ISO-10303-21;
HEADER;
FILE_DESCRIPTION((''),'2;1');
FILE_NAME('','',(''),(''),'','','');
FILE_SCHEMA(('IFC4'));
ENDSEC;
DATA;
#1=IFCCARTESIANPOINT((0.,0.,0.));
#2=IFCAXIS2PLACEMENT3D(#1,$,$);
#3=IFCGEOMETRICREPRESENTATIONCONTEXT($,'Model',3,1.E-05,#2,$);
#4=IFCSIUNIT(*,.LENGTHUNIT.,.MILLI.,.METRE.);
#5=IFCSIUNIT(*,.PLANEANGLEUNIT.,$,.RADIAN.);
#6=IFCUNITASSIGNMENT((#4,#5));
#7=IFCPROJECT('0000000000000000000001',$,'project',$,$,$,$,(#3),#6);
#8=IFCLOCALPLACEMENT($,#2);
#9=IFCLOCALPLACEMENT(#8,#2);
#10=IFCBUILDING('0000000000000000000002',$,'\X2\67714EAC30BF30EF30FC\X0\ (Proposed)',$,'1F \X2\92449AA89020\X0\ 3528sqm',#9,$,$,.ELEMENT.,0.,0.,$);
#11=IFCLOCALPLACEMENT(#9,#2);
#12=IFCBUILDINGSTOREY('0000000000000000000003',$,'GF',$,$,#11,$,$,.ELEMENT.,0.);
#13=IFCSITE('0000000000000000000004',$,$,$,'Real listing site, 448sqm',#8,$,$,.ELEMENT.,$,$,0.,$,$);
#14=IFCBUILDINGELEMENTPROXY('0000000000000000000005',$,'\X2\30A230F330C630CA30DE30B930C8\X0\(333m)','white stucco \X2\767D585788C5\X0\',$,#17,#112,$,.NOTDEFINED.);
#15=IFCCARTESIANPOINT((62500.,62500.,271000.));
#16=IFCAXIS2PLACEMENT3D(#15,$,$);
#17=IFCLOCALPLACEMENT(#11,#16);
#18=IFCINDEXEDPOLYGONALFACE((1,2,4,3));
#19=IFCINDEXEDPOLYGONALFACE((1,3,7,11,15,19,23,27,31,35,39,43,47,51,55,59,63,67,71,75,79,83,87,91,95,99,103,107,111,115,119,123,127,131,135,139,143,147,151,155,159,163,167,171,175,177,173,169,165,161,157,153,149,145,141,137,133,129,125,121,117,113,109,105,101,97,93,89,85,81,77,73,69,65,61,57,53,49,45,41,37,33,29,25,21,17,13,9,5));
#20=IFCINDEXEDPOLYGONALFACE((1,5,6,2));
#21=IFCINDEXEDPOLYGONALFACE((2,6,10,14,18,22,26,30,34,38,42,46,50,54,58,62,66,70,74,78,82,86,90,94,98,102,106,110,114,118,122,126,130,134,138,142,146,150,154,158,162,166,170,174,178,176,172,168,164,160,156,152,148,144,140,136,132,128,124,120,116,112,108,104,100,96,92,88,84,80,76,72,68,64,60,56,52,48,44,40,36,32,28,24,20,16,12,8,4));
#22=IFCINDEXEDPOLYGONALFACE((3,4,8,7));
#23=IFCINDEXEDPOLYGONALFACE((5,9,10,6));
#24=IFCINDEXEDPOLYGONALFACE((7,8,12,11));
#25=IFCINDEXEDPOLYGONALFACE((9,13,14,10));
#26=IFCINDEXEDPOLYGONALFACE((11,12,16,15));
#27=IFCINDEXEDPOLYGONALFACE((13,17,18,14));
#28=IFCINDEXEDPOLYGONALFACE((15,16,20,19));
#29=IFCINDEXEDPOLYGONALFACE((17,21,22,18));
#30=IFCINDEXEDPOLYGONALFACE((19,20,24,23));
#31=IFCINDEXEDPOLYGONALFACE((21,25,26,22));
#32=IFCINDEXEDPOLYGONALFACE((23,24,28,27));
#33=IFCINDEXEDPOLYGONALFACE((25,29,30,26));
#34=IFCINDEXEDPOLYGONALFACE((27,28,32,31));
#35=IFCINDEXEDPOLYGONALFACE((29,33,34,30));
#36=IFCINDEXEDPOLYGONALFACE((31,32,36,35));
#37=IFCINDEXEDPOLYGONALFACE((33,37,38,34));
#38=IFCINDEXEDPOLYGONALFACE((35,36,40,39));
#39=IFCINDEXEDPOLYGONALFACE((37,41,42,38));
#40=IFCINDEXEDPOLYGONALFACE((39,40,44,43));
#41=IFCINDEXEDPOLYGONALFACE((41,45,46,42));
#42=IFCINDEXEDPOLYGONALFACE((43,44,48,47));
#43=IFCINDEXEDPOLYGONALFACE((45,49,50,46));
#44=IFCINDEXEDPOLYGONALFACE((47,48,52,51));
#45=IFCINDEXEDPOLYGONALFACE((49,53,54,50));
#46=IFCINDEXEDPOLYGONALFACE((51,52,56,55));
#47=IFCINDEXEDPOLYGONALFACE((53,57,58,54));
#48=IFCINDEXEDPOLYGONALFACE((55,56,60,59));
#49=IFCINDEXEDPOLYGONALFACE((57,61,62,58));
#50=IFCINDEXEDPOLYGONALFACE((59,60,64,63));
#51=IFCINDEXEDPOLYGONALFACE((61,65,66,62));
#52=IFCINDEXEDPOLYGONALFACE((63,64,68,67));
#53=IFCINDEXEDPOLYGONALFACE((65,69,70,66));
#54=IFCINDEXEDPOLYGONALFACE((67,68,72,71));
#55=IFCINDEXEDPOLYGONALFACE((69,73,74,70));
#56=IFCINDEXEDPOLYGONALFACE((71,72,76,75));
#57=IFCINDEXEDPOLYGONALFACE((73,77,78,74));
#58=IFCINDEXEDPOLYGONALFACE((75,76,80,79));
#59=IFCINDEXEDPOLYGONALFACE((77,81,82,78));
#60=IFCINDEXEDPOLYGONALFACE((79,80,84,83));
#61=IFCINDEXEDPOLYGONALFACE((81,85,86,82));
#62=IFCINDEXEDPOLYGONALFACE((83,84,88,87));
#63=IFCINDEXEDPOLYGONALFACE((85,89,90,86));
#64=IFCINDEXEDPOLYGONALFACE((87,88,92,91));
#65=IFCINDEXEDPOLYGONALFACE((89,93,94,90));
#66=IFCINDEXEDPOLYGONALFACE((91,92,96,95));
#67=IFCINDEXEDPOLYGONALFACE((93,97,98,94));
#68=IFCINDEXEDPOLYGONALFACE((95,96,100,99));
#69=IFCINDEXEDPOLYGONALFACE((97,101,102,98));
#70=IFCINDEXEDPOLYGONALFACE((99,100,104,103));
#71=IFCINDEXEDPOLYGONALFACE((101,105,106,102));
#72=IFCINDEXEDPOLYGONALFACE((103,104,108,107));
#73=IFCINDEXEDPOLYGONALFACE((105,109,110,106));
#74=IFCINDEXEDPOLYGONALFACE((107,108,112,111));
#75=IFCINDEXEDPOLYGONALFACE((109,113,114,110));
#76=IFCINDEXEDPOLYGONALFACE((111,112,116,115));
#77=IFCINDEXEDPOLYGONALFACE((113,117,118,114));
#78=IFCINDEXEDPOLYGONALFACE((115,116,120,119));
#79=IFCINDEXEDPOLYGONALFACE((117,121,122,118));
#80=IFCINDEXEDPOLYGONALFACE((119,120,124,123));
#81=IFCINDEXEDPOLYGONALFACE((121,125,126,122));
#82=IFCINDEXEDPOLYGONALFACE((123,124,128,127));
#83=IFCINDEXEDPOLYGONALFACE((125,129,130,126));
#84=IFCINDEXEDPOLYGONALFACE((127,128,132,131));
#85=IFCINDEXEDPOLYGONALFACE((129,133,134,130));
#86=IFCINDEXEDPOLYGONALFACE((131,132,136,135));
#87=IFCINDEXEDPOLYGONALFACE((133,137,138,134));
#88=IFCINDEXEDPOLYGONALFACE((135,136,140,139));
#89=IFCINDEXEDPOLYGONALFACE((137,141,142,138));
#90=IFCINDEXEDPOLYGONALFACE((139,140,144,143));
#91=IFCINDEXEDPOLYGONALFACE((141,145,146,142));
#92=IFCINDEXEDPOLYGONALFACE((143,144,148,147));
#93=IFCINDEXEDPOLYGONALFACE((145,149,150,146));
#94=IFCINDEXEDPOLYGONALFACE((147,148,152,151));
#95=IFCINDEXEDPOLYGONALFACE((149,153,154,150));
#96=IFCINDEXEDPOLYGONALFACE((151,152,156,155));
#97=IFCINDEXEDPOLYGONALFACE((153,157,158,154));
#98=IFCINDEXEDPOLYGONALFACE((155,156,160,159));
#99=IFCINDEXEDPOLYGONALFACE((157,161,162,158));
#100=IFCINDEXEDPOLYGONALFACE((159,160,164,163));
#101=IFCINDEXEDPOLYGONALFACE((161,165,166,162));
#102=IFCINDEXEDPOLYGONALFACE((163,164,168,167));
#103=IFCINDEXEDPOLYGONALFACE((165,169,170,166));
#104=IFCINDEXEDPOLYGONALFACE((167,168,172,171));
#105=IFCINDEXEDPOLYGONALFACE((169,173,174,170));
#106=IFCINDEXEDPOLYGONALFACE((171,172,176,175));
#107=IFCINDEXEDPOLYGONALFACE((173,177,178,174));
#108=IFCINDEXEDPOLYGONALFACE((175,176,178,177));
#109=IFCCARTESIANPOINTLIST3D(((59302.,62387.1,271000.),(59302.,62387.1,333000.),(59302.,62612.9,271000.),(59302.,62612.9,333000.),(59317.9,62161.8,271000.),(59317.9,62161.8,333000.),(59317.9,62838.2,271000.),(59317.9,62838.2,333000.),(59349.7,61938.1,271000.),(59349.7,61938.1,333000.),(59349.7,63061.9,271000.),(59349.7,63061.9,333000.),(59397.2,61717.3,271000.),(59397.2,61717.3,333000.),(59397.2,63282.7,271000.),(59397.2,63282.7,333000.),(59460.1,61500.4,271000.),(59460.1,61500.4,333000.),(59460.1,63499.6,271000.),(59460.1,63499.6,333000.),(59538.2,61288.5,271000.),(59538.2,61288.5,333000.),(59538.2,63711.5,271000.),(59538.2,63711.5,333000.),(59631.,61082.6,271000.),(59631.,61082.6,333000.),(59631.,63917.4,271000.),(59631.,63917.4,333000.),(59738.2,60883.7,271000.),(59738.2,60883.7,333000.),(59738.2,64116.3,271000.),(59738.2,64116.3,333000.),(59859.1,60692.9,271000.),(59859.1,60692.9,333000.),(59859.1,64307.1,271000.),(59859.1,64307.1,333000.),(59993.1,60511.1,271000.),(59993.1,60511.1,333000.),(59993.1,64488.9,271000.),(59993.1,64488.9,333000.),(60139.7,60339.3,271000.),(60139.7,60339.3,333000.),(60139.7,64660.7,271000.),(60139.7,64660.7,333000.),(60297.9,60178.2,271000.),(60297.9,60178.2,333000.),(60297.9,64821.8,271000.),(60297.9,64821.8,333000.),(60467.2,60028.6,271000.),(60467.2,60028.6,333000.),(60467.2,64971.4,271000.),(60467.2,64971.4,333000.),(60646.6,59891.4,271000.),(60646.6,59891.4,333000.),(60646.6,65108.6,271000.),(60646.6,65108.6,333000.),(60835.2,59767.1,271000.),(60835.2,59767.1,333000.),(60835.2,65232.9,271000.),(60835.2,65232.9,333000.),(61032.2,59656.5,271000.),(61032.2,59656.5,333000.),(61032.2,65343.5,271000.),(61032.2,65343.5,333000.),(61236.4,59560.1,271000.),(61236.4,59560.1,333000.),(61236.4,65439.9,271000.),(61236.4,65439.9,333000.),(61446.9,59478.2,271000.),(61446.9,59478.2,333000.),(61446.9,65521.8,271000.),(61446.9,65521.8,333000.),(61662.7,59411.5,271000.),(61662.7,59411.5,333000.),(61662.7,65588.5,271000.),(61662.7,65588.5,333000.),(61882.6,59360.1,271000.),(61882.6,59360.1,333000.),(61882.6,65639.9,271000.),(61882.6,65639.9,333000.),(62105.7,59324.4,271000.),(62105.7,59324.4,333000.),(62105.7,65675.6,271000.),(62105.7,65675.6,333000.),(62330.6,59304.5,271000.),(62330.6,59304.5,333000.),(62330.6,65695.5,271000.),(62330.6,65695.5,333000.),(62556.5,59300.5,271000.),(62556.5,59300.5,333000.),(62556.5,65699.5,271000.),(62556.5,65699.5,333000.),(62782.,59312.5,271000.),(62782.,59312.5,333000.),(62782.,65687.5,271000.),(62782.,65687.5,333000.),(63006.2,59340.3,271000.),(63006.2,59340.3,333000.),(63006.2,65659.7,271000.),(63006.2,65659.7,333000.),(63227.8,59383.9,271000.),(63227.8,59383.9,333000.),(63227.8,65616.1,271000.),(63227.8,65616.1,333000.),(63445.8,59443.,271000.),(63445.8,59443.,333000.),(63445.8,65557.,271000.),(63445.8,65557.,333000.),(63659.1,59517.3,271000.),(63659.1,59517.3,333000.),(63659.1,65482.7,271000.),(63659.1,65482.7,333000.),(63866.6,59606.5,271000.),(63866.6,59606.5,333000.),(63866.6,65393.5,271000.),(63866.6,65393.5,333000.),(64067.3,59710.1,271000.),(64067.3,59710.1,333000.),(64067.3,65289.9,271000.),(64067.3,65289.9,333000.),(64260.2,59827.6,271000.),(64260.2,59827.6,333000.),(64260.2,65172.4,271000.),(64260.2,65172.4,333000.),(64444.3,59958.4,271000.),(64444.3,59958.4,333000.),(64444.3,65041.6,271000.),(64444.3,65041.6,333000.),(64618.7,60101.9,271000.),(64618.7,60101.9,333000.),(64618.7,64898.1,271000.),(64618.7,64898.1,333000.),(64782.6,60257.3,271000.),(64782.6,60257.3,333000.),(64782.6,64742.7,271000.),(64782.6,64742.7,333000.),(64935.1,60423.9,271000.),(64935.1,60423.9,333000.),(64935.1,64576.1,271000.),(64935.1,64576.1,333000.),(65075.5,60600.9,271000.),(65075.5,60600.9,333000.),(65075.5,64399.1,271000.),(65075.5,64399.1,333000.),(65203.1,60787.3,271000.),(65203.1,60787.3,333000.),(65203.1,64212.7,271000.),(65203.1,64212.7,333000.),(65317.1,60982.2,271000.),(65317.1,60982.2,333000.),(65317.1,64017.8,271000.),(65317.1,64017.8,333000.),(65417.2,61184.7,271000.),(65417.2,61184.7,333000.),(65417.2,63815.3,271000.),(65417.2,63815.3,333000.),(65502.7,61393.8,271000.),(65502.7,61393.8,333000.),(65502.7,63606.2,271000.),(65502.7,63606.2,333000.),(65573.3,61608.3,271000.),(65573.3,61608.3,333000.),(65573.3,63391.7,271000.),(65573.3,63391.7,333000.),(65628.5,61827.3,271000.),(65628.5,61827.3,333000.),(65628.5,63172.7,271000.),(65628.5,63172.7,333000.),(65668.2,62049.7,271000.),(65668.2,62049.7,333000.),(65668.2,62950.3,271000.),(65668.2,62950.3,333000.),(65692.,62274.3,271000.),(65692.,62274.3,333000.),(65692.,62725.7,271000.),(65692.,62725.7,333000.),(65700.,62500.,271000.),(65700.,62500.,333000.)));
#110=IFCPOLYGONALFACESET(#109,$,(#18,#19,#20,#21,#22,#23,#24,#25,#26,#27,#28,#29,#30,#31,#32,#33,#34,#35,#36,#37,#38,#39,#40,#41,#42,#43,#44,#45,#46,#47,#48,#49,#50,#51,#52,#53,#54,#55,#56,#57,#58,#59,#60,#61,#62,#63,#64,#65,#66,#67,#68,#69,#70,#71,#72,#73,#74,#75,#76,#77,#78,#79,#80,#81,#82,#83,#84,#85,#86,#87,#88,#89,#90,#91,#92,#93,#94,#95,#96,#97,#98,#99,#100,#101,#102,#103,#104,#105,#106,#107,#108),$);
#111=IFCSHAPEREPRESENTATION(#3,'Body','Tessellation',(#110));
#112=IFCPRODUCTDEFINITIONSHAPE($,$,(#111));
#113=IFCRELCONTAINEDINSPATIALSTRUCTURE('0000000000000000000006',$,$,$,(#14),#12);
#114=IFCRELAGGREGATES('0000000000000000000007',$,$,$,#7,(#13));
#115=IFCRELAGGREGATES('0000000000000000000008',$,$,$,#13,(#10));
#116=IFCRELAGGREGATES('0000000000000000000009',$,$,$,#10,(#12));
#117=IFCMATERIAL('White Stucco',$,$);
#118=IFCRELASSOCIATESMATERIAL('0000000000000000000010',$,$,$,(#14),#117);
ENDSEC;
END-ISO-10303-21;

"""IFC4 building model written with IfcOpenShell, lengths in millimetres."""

from ifc_helpers import new_model, si_unit, frame, origin, origin_2d, place, context, project, spatial, circle, extrude, material, element, save


model = new_model("IFC4")

# Units and contexts
model_context = context("Model", 3, precision=1e-05, world=origin())
ifc_project = project(units=[si_unit("LENGTHUNIT", "METRE", prefix="MILLI"), si_unit("PLANEANGLEUNIT", "RADIAN")], contexts=[model_context])

# Site, building, storey
site_placement = place(None, origin())
site = spatial("IfcSite", under=ifc_project, at=site_placement, ObjectType="Real listing site, 448sqm", CompositionType="ELEMENT", RefElevation=0.0)
building_placement = place(site_placement, origin())
building = spatial("IfcBuilding", under=site, at=building_placement, Name="東京タワー (Proposed)", ObjectType="1F 鉄骨造 3528sqm", CompositionType="ELEMENT", ElevationOfRefHeight=0.0, ElevationOfTerrain=0.0)
storey_placement = place(building_placement, origin())
storey = spatial("IfcBuildingStorey", under=building, at=storey_placement, Name="GF", CompositionType="ELEMENT", Elevation=0.0)

# Shared definitions
ifc_material_1 = material(Name="White Stucco")

# Building element proxy
proxy_1_placement = place(storey_placement, frame((62500.0, 62500.0, 271000.0)))
element("IfcBuildingElementProxy", 1, at=proxy_1_placement, inside=storey, material=ifc_material_1, Name="アンテナマスト(333m)", Description="white stucco 白塗装", PredefinedType="NOTDEFINED", context=model_context, shape_type="SweptSolid", body=[
    extrude(circle(Radius=3200.0, at=origin_2d()), frame((62500.0, 62500.0, 271000.0)), (0.0, 0.0, 1.0), 62000.0),
])

save(model, "model.ifc")
